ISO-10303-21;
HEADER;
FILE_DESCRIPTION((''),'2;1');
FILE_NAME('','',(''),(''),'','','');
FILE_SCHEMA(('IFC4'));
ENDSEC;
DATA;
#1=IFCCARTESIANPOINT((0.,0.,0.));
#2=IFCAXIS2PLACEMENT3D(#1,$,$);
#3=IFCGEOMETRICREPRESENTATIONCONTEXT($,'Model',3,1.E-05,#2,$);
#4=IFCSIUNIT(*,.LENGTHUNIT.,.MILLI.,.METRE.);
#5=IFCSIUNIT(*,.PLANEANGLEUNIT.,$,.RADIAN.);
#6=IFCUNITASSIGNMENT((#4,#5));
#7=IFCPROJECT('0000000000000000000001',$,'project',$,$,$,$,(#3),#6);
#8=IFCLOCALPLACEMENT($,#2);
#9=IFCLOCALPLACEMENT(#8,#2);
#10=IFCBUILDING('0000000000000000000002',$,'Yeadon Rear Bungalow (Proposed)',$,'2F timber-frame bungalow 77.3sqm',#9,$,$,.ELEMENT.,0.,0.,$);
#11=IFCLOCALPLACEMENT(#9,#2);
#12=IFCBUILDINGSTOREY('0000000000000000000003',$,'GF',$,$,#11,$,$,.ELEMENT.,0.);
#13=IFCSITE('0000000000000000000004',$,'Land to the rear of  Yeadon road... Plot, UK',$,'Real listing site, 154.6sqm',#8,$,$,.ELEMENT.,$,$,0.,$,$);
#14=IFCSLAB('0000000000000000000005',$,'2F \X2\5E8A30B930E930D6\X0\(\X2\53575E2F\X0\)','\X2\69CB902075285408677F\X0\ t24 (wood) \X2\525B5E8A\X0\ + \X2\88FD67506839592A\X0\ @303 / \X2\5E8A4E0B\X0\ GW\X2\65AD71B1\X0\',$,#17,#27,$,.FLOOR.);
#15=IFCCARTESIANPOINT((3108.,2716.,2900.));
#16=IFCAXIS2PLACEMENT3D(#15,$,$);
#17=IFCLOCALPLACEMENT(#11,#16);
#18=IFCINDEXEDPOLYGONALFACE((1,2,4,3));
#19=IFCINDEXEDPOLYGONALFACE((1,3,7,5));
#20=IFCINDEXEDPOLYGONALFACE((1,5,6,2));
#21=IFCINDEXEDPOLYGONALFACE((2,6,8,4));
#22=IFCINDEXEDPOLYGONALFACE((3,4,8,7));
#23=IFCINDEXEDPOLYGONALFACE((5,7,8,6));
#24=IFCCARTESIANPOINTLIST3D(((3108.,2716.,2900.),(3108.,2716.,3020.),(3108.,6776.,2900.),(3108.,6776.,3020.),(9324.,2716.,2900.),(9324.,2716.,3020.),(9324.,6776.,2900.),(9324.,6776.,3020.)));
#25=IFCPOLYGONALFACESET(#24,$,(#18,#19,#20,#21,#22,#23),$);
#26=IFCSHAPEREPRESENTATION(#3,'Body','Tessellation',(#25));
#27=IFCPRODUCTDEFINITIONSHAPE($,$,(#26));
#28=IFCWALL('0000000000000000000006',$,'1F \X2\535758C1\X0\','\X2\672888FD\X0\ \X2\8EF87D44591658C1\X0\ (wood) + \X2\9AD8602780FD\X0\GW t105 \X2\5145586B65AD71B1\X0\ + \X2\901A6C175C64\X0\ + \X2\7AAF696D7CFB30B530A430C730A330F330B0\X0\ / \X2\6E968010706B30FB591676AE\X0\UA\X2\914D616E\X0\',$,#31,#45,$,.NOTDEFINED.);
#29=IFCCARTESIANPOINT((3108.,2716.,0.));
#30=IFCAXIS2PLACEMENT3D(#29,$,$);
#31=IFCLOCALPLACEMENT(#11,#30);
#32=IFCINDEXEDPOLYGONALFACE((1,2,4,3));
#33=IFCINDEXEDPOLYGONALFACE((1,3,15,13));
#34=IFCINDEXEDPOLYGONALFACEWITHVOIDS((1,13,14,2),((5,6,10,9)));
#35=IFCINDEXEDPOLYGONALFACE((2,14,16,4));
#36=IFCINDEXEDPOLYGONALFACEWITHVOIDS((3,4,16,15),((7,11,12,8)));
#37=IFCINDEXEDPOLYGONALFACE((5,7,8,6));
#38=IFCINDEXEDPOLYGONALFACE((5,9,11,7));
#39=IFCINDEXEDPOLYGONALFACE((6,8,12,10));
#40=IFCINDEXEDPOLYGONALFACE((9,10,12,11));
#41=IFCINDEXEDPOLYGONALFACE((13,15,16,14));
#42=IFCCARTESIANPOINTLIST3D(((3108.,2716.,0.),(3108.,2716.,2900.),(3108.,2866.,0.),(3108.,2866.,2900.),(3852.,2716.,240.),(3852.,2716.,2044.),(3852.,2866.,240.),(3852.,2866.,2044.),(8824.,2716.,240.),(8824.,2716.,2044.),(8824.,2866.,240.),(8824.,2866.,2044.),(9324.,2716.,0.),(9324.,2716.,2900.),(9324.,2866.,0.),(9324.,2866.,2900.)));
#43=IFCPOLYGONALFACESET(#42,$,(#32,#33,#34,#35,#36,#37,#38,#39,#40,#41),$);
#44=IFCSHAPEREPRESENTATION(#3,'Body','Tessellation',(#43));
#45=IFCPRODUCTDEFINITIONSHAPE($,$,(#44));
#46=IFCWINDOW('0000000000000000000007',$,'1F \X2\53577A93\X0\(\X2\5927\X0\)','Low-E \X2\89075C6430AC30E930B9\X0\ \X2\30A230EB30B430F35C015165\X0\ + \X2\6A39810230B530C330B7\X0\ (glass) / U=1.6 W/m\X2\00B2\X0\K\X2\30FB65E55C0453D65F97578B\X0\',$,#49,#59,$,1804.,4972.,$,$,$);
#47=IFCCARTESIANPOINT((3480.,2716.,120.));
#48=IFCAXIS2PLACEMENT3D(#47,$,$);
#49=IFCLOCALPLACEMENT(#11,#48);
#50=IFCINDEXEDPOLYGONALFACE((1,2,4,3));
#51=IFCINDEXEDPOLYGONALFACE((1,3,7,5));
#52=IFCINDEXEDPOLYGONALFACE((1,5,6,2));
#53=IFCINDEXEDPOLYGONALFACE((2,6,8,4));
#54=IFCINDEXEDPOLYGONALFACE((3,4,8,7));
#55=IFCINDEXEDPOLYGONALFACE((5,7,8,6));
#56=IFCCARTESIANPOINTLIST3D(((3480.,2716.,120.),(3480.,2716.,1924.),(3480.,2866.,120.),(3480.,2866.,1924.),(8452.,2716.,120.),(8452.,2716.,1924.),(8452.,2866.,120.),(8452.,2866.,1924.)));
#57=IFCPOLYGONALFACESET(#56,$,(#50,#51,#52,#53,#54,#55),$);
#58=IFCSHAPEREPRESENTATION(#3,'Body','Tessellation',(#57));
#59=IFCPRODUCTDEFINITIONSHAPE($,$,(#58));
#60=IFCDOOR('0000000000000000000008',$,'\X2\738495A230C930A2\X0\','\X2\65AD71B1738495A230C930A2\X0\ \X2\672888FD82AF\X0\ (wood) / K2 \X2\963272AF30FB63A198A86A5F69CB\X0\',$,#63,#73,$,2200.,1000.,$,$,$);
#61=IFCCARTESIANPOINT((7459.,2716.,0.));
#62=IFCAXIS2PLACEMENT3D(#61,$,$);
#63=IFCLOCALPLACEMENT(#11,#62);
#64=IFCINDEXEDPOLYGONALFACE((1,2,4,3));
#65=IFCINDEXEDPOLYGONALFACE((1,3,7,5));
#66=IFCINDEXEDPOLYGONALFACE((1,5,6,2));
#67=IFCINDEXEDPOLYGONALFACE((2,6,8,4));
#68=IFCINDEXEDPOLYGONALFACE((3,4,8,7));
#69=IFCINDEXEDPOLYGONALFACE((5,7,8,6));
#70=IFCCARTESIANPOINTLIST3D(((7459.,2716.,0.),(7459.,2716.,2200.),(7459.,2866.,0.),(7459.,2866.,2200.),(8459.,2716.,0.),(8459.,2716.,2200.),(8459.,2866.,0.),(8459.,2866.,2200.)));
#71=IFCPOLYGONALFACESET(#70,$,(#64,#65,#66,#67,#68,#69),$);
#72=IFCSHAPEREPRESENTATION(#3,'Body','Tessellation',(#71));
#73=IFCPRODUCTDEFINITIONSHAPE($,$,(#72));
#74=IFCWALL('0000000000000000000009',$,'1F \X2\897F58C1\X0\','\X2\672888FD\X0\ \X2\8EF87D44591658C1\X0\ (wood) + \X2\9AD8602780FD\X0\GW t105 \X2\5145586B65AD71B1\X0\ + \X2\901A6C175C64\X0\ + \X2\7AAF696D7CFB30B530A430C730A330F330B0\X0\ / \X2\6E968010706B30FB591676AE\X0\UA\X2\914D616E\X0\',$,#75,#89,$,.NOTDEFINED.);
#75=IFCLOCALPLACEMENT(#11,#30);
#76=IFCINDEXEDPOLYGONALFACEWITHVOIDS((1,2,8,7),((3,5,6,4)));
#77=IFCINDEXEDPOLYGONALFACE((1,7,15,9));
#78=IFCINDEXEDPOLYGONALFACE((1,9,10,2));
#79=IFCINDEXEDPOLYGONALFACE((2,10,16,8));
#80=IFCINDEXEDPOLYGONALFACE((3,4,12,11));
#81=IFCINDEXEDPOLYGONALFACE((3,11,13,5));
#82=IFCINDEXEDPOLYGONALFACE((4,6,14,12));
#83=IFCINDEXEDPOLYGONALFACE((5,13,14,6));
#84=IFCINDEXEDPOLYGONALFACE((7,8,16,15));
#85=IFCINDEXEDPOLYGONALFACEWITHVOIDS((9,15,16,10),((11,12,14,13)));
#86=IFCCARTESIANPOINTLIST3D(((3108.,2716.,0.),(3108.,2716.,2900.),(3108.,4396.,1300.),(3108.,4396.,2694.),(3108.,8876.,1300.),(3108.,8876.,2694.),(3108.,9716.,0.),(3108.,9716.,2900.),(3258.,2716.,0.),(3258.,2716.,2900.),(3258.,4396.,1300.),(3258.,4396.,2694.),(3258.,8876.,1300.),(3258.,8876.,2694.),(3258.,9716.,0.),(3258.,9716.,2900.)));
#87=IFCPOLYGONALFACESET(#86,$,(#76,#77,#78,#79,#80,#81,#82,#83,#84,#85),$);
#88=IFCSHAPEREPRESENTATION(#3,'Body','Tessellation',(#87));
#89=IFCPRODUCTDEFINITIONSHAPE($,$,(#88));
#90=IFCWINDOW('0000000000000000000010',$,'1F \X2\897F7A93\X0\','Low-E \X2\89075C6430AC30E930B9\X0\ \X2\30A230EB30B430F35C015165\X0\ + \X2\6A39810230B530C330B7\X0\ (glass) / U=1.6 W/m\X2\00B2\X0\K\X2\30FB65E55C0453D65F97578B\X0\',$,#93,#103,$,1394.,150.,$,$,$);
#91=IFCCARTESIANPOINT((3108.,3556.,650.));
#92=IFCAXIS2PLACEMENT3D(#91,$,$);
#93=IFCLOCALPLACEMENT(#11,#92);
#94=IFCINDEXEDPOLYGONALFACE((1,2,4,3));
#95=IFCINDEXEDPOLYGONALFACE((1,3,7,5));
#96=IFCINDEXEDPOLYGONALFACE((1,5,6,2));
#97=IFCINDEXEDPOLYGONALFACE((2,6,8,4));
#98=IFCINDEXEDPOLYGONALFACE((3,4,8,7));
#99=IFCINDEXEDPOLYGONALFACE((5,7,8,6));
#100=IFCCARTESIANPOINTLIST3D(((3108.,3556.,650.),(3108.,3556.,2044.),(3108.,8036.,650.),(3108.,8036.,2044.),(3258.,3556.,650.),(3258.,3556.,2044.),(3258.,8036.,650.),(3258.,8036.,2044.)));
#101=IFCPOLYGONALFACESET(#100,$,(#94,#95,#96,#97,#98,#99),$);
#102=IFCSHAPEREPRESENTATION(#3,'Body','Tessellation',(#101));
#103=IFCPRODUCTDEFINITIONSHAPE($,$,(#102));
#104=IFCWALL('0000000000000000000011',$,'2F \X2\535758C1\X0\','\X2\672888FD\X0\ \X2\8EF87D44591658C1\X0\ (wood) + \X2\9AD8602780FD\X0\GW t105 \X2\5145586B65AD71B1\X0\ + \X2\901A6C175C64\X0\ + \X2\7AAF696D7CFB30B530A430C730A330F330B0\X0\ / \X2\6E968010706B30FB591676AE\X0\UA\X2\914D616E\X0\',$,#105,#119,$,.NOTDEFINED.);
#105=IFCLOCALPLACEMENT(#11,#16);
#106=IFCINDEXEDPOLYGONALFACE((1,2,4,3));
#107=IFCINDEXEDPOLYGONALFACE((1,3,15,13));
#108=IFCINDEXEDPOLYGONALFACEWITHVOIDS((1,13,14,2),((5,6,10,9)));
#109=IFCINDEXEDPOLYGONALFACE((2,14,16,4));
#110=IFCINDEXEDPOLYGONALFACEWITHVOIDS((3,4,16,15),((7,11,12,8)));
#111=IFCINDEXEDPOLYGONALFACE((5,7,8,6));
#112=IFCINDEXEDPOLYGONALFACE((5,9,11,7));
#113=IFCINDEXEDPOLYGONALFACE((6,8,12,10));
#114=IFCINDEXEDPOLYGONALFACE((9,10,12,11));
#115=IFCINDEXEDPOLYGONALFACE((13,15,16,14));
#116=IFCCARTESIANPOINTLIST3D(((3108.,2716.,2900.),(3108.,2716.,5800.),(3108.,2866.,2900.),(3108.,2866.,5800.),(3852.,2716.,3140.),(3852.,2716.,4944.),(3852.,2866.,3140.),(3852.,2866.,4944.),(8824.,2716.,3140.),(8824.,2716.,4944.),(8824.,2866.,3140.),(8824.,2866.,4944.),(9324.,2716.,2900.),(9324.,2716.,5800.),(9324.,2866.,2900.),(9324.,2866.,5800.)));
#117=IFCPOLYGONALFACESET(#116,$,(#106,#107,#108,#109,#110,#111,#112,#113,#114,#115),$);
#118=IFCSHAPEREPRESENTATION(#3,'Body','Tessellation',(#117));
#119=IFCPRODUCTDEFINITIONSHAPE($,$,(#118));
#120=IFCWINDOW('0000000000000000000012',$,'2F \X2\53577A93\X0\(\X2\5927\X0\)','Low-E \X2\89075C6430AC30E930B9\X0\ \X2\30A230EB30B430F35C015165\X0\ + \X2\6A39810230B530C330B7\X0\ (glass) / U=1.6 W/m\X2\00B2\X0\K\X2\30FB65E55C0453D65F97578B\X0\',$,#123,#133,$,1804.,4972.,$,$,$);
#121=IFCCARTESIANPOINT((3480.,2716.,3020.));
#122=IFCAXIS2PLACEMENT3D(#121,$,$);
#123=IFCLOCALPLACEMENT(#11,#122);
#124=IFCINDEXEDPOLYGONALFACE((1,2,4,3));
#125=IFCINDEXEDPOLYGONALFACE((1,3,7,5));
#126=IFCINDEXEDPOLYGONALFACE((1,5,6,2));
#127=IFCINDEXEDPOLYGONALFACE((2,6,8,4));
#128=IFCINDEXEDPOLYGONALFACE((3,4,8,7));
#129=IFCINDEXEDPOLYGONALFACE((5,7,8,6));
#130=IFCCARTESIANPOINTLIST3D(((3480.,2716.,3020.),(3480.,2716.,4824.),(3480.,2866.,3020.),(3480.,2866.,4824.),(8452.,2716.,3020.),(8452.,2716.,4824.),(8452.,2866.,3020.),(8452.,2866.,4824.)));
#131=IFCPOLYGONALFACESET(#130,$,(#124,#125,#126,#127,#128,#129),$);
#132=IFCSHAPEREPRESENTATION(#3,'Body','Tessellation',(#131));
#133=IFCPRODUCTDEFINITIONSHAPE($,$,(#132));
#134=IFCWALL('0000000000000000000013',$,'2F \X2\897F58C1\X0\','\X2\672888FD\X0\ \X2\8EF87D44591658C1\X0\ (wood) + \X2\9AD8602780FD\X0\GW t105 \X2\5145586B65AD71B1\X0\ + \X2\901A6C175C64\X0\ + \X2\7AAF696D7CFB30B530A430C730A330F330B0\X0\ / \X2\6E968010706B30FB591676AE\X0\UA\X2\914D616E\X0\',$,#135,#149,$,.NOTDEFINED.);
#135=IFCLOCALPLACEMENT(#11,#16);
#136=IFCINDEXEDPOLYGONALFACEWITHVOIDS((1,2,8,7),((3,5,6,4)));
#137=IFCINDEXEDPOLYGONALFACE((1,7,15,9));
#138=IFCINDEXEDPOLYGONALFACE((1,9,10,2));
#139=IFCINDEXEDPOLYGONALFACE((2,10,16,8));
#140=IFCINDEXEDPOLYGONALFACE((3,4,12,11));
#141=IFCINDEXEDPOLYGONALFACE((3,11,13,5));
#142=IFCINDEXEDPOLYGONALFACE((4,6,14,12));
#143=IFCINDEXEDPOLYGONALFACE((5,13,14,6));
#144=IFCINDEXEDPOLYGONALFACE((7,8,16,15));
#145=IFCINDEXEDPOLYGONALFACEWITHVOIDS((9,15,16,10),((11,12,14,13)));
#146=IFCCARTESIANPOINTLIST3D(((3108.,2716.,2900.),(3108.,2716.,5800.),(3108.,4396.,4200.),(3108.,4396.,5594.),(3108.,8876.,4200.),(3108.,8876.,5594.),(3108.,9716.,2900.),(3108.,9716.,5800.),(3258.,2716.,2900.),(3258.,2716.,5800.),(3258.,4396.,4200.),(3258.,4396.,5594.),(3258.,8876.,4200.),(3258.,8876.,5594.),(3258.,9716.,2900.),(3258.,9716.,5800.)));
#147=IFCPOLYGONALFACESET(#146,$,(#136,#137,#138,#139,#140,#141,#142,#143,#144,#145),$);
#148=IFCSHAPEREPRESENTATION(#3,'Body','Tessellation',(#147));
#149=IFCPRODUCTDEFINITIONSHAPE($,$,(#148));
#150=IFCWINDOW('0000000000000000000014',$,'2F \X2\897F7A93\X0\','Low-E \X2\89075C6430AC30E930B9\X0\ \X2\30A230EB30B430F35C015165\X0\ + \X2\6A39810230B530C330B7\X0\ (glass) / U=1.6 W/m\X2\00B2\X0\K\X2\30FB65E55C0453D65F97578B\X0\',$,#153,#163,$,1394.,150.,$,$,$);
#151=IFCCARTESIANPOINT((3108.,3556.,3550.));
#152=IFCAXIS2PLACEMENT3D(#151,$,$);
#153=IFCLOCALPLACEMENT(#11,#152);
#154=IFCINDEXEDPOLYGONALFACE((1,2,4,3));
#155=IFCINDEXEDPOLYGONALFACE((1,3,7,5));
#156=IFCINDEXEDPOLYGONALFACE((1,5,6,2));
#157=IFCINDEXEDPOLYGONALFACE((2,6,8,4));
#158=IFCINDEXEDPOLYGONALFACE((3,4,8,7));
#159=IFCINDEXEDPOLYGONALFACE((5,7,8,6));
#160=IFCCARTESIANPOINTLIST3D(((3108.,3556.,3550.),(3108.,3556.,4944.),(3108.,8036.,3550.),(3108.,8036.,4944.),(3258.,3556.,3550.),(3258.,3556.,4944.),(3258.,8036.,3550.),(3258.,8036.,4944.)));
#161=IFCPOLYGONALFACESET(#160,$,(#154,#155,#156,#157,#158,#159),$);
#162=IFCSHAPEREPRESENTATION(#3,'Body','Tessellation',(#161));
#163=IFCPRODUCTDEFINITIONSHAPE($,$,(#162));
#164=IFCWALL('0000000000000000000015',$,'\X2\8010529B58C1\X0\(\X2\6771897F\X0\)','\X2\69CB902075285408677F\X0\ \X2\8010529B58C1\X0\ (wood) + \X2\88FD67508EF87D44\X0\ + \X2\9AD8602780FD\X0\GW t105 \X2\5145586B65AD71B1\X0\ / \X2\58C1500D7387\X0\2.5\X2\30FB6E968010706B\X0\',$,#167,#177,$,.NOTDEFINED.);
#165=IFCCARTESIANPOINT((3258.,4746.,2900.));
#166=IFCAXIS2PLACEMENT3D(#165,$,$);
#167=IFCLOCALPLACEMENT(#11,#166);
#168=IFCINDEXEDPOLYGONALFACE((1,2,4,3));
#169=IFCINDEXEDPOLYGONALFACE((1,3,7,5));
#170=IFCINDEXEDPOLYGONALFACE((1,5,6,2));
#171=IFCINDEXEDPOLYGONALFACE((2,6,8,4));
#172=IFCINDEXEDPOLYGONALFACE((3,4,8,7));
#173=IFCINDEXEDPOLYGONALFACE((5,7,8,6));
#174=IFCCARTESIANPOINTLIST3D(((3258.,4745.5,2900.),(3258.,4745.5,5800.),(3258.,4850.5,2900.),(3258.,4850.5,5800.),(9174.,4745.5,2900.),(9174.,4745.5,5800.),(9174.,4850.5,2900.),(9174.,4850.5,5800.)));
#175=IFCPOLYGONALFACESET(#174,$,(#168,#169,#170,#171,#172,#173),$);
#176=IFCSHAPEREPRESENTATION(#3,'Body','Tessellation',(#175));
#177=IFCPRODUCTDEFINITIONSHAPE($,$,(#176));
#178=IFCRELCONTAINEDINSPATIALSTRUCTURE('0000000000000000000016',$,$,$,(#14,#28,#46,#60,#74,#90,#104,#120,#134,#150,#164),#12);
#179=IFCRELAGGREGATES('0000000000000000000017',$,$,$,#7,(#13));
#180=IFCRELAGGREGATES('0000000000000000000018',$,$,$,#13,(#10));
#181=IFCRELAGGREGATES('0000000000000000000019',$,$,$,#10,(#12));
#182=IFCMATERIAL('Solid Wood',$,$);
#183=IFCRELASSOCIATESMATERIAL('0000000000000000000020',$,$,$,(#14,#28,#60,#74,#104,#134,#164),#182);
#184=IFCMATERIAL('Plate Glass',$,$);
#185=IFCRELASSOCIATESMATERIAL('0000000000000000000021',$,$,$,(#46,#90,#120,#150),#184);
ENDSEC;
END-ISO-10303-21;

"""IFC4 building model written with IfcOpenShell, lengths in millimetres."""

from ifc_helpers import new_model, si_unit, frame, frame_2d, origin, place, context, project, spatial, rectangle, extrude, material, element, fill, save


model = new_model("IFC4")

# Units and contexts
model_context = context("Model", 3, precision=1e-05, world=origin())
ifc_project = project(units=[si_unit("LENGTHUNIT", "METRE", prefix="MILLI"), si_unit("PLANEANGLEUNIT", "RADIAN")], contexts=[model_context])

# Site, building, storey
site_placement = place(None, origin())
site = spatial("IfcSite", under=ifc_project, at=site_placement, Name="Land to the rear of  Yeadon road... Plot, UK", ObjectType="Real listing site, 154.6sqm", CompositionType="ELEMENT", RefElevation=0.0)
building_placement = place(site_placement, origin())
building = spatial("IfcBuilding", under=site, at=building_placement, Name="Yeadon Rear Bungalow (Proposed)", ObjectType="2F timber-frame bungalow 77.3sqm", CompositionType="ELEMENT", ElevationOfRefHeight=0.0, ElevationOfTerrain=0.0)
storey_placement = place(building_placement, origin())
storey = spatial("IfcBuildingStorey", under=building, at=storey_placement, Name="GF", CompositionType="ELEMENT", Elevation=0.0)

# Slab
ifc_material_1 = material(Name="Solid Wood")
slab_1_placement = place(storey_placement, frame((3108.0, 2716.0, 2900.0)))
element("IfcSlab", 1, at=slab_1_placement, inside=storey, material=ifc_material_1, Name="2F 床スラブ(南帯)", Description="構造用合板 t24 (wood) 剛床 + 製材根太 @303 / 床下 GW断熱", PredefinedType="FLOOR", context=model_context, shape_type="SweptSolid", body=[
    extrude(rectangle(XDim=6216.0, YDim=4060.0, at=frame_2d((3108.0, 2030.0))), frame((3108.0, 2716.0, 2900.0)), (0.0, 0.0, 1.0), 120.0),
])

# Wall, openings, window, door
wall_1_placement = place(storey_placement, frame((3108.0, 2716.0, 0.0)))
wall_1 = element("IfcWall", 2, at=wall_1_placement, inside=storey, material=ifc_material_1, Name="1F 南壁", Description="木製 軸組外壁 (wood) + 高性能GW t105 充填断熱 + 通気層 + 窯業系サイディング / 準耐火・外皮UA配慮", PredefinedType="NOTDEFINED", context=model_context, shape_type="SweptSolid", body=[
    extrude(rectangle(XDim=6216.0, YDim=150.0, at=frame_2d((3108.0, 75.0))), frame((3108.0, 2716.0, 0.0)), (0.0, 0.0, 1.0), 2900.0),
])
opening_1_placement = place(storey_placement, frame((3480.0, 2716.0, 120.0)))
opening_1 = element("IfcOpeningElement", 3, at=opening_1_placement, cuts=wall_1, PredefinedType="NOTDEFINED", context=model_context, shape_type="SweptSolid", body=[
    extrude(rectangle(XDim=4972.0, YDim=150.0, at=frame_2d((2486.0, 75.0))), frame((3480.0, 2716.0, 120.0)), (0.0, 0.0, 1.0), 1804.0),
])
opening_2_placement = place(storey_placement, frame((7459.0, 2716.0, 0.0)))
opening_2 = element("IfcOpeningElement", 4, at=opening_2_placement, cuts=wall_1, PredefinedType="NOTDEFINED", context=model_context, shape_type="SweptSolid", body=[
    extrude(rectangle(XDim=1000.0, YDim=150.0, at=frame_2d((500.0, 75.0))), frame((7459.0, 2716.0, 0.0)), (0.0, 0.0, 1.0), 2200.0),
])
ifc_material_2 = material(Name="Plate Glass")
window_1_placement = place(storey_placement, frame((3480.0, 2716.0, 120.0)))
window_1 = element("IfcWindow", 5, at=window_1_placement, inside=storey, material=ifc_material_2, Name="1F 南窓(大)", Description="Low-E 複層ガラス アルゴン封入 + 樹脂サッシ (glass) / U=1.6 W/m²K・日射取得型", OverallHeight=1804.0, OverallWidth=4972.0, context=model_context, shape_type="SweptSolid", body=[
    extrude(rectangle(XDim=4972.0, YDim=150.0, at=frame_2d((2486.0, 75.0))), frame((3480.0, 2716.0, 120.0)), (0.0, 0.0, 1.0), 1804.0),
])
fill(opening_1, window_1)
door_placement = place(storey_placement, frame((7459.0, 2716.0, 0.0)))
door = element("IfcDoor", 6, at=door_placement, inside=storey, material=ifc_material_1, Name="玄関ドア", Description="断熱玄関ドア 木製芯 (wood) / K2 防犯・採風機構", OverallHeight=2200.0, OverallWidth=1000.0, context=model_context, shape_type="SweptSolid", body=[
    extrude(rectangle(XDim=1000.0, YDim=150.0, at=frame_2d((500.0, 75.0))), frame((7459.0, 2716.0, 0.0)), (0.0, 0.0, 1.0), 2200.0),
])
fill(opening_2, door)

# Wall, opening, window
wall_2_placement = place(storey_placement, frame((3108.0, 2716.0, 0.0)))
wall_2 = element("IfcWall", 7, at=wall_2_placement, inside=storey, material=ifc_material_1, Name="1F 西壁", Description="木製 軸組外壁 (wood) + 高性能GW t105 充填断熱 + 通気層 + 窯業系サイディング / 準耐火・外皮UA配慮", PredefinedType="NOTDEFINED", context=model_context, shape_type="SweptSolid", body=[
    extrude(rectangle(XDim=150.0, YDim=7000.0, at=frame_2d((75.0, 3500.0))), frame((3108.0, 2716.0, 0.0)), (0.0, 0.0, 1.0), 2900.0),
])
opening_3_placement = place(storey_placement, frame((3108.0, 3556.0, 650.0)))
opening_3 = element("IfcOpeningElement", 8, at=opening_3_placement, cuts=wall_2, PredefinedType="NOTDEFINED", context=model_context, shape_type="SweptSolid", body=[
    extrude(rectangle(XDim=150.0, YDim=4480.0, at=frame_2d((75.0, 2240.0))), frame((3108.0, 3556.0, 650.0)), (0.0, 0.0, 1.0), 1394.0),
])
window_2_placement = place(storey_placement, frame((3108.0, 3556.0, 650.0)))
window_2 = element("IfcWindow", 9, at=window_2_placement, inside=storey, material=ifc_material_2, Name="1F 西窓", Description="Low-E 複層ガラス アルゴン封入 + 樹脂サッシ (glass) / U=1.6 W/m²K・日射取得型", OverallHeight=1394.0, OverallWidth=150.0, context=model_context, shape_type="SweptSolid", body=[
    extrude(rectangle(XDim=150.0, YDim=4480.0, at=frame_2d((75.0, 2240.0))), frame((3108.0, 3556.0, 650.0)), (0.0, 0.0, 1.0), 1394.0),
])
fill(opening_3, window_2)

# Walls, openings, windows
wall_3_placement = place(storey_placement, frame((3108.0, 2716.0, 2900.0)))
wall_3 = element("IfcWall", 10, at=wall_3_placement, inside=storey, material=ifc_material_1, Name="2F 南壁", Description="木製 軸組外壁 (wood) + 高性能GW t105 充填断熱 + 通気層 + 窯業系サイディング / 準耐火・外皮UA配慮", PredefinedType="NOTDEFINED", context=model_context, shape_type="SweptSolid", body=[
    extrude(rectangle(XDim=6216.0, YDim=150.0, at=frame_2d((3108.0, 75.0))), frame((3108.0, 2716.0, 2900.0)), (0.0, 0.0, 1.0), 2900.0),
])
opening_4_placement = place(storey_placement, frame((3480.0, 2716.0, 3020.0)))
opening_4 = element("IfcOpeningElement", 11, at=opening_4_placement, cuts=wall_3, PredefinedType="NOTDEFINED", context=model_context, shape_type="SweptSolid", body=[
    extrude(rectangle(XDim=4972.0, YDim=150.0, at=frame_2d((2486.0, 75.0))), frame((3480.0, 2716.0, 3020.0)), (0.0, 0.0, 1.0), 1804.0),
])
window_3_placement = place(storey_placement, frame((3480.0, 2716.0, 3020.0)))
window_3 = element("IfcWindow", 12, at=window_3_placement, inside=storey, material=ifc_material_2, Name="2F 南窓(大)", Description="Low-E 複層ガラス アルゴン封入 + 樹脂サッシ (glass) / U=1.6 W/m²K・日射取得型", OverallHeight=1804.0, OverallWidth=4972.0, context=model_context, shape_type="SweptSolid", body=[
    extrude(rectangle(XDim=4972.0, YDim=150.0, at=frame_2d((2486.0, 75.0))), frame((3480.0, 2716.0, 3020.0)), (0.0, 0.0, 1.0), 1804.0),
])
fill(opening_4, window_3)
wall_4_placement = place(storey_placement, frame((3108.0, 2716.0, 2900.0)))
wall_4 = element("IfcWall", 13, at=wall_4_placement, inside=storey, material=ifc_material_1, Name="2F 西壁", Description="木製 軸組外壁 (wood) + 高性能GW t105 充填断熱 + 通気層 + 窯業系サイディング / 準耐火・外皮UA配慮", PredefinedType="NOTDEFINED", context=model_context, shape_type="SweptSolid", body=[
    extrude(rectangle(XDim=150.0, YDim=7000.0, at=frame_2d((75.0, 3500.0))), frame((3108.0, 2716.0, 2900.0)), (0.0, 0.0, 1.0), 2900.0),
])
opening_5_placement = place(storey_placement, frame((3108.0, 3556.0, 3550.0)))
opening_5 = element("IfcOpeningElement", 14, at=opening_5_placement, cuts=wall_4, PredefinedType="NOTDEFINED", context=model_context, shape_type="SweptSolid", body=[
    extrude(rectangle(XDim=150.0, YDim=4480.0, at=frame_2d((75.0, 2240.0))), frame((3108.0, 3556.0, 3550.0)), (0.0, 0.0, 1.0), 1394.0),
])
window_4_placement = place(storey_placement, frame((3108.0, 3556.0, 3550.0)))
window_4 = element("IfcWindow", 15, at=window_4_placement, inside=storey, material=ifc_material_2, Name="2F 西窓", Description="Low-E 複層ガラス アルゴン封入 + 樹脂サッシ (glass) / U=1.6 W/m²K・日射取得型", OverallHeight=1394.0, OverallWidth=150.0, context=model_context, shape_type="SweptSolid", body=[
    extrude(rectangle(XDim=150.0, YDim=4480.0, at=frame_2d((75.0, 2240.0))), frame((3108.0, 3556.0, 3550.0)), (0.0, 0.0, 1.0), 1394.0),
])
fill(opening_5, window_4)

# Wall
wall_5_placement = place(storey_placement, frame((3258.0, 4746.0, 2900.0)))
element("IfcWall", 16, at=wall_5_placement, inside=storey, material=ifc_material_1, Name="耐力壁(東西)", Description="構造用合板 耐力壁 (wood) + 製材軸組 + 高性能GW t105 充填断熱 / 壁倍率2.5・準耐火", PredefinedType="NOTDEFINED", context=model_context, shape_type="SweptSolid", body=[
    extrude(rectangle(XDim=5916.0, YDim=105.0, at=frame_2d((2958.0, 52.0))), frame((3258.0, 4746.0, 2900.0)), (0.0, 0.0, 1.0), 2900.0),
])

save(model, "model.ifc")
